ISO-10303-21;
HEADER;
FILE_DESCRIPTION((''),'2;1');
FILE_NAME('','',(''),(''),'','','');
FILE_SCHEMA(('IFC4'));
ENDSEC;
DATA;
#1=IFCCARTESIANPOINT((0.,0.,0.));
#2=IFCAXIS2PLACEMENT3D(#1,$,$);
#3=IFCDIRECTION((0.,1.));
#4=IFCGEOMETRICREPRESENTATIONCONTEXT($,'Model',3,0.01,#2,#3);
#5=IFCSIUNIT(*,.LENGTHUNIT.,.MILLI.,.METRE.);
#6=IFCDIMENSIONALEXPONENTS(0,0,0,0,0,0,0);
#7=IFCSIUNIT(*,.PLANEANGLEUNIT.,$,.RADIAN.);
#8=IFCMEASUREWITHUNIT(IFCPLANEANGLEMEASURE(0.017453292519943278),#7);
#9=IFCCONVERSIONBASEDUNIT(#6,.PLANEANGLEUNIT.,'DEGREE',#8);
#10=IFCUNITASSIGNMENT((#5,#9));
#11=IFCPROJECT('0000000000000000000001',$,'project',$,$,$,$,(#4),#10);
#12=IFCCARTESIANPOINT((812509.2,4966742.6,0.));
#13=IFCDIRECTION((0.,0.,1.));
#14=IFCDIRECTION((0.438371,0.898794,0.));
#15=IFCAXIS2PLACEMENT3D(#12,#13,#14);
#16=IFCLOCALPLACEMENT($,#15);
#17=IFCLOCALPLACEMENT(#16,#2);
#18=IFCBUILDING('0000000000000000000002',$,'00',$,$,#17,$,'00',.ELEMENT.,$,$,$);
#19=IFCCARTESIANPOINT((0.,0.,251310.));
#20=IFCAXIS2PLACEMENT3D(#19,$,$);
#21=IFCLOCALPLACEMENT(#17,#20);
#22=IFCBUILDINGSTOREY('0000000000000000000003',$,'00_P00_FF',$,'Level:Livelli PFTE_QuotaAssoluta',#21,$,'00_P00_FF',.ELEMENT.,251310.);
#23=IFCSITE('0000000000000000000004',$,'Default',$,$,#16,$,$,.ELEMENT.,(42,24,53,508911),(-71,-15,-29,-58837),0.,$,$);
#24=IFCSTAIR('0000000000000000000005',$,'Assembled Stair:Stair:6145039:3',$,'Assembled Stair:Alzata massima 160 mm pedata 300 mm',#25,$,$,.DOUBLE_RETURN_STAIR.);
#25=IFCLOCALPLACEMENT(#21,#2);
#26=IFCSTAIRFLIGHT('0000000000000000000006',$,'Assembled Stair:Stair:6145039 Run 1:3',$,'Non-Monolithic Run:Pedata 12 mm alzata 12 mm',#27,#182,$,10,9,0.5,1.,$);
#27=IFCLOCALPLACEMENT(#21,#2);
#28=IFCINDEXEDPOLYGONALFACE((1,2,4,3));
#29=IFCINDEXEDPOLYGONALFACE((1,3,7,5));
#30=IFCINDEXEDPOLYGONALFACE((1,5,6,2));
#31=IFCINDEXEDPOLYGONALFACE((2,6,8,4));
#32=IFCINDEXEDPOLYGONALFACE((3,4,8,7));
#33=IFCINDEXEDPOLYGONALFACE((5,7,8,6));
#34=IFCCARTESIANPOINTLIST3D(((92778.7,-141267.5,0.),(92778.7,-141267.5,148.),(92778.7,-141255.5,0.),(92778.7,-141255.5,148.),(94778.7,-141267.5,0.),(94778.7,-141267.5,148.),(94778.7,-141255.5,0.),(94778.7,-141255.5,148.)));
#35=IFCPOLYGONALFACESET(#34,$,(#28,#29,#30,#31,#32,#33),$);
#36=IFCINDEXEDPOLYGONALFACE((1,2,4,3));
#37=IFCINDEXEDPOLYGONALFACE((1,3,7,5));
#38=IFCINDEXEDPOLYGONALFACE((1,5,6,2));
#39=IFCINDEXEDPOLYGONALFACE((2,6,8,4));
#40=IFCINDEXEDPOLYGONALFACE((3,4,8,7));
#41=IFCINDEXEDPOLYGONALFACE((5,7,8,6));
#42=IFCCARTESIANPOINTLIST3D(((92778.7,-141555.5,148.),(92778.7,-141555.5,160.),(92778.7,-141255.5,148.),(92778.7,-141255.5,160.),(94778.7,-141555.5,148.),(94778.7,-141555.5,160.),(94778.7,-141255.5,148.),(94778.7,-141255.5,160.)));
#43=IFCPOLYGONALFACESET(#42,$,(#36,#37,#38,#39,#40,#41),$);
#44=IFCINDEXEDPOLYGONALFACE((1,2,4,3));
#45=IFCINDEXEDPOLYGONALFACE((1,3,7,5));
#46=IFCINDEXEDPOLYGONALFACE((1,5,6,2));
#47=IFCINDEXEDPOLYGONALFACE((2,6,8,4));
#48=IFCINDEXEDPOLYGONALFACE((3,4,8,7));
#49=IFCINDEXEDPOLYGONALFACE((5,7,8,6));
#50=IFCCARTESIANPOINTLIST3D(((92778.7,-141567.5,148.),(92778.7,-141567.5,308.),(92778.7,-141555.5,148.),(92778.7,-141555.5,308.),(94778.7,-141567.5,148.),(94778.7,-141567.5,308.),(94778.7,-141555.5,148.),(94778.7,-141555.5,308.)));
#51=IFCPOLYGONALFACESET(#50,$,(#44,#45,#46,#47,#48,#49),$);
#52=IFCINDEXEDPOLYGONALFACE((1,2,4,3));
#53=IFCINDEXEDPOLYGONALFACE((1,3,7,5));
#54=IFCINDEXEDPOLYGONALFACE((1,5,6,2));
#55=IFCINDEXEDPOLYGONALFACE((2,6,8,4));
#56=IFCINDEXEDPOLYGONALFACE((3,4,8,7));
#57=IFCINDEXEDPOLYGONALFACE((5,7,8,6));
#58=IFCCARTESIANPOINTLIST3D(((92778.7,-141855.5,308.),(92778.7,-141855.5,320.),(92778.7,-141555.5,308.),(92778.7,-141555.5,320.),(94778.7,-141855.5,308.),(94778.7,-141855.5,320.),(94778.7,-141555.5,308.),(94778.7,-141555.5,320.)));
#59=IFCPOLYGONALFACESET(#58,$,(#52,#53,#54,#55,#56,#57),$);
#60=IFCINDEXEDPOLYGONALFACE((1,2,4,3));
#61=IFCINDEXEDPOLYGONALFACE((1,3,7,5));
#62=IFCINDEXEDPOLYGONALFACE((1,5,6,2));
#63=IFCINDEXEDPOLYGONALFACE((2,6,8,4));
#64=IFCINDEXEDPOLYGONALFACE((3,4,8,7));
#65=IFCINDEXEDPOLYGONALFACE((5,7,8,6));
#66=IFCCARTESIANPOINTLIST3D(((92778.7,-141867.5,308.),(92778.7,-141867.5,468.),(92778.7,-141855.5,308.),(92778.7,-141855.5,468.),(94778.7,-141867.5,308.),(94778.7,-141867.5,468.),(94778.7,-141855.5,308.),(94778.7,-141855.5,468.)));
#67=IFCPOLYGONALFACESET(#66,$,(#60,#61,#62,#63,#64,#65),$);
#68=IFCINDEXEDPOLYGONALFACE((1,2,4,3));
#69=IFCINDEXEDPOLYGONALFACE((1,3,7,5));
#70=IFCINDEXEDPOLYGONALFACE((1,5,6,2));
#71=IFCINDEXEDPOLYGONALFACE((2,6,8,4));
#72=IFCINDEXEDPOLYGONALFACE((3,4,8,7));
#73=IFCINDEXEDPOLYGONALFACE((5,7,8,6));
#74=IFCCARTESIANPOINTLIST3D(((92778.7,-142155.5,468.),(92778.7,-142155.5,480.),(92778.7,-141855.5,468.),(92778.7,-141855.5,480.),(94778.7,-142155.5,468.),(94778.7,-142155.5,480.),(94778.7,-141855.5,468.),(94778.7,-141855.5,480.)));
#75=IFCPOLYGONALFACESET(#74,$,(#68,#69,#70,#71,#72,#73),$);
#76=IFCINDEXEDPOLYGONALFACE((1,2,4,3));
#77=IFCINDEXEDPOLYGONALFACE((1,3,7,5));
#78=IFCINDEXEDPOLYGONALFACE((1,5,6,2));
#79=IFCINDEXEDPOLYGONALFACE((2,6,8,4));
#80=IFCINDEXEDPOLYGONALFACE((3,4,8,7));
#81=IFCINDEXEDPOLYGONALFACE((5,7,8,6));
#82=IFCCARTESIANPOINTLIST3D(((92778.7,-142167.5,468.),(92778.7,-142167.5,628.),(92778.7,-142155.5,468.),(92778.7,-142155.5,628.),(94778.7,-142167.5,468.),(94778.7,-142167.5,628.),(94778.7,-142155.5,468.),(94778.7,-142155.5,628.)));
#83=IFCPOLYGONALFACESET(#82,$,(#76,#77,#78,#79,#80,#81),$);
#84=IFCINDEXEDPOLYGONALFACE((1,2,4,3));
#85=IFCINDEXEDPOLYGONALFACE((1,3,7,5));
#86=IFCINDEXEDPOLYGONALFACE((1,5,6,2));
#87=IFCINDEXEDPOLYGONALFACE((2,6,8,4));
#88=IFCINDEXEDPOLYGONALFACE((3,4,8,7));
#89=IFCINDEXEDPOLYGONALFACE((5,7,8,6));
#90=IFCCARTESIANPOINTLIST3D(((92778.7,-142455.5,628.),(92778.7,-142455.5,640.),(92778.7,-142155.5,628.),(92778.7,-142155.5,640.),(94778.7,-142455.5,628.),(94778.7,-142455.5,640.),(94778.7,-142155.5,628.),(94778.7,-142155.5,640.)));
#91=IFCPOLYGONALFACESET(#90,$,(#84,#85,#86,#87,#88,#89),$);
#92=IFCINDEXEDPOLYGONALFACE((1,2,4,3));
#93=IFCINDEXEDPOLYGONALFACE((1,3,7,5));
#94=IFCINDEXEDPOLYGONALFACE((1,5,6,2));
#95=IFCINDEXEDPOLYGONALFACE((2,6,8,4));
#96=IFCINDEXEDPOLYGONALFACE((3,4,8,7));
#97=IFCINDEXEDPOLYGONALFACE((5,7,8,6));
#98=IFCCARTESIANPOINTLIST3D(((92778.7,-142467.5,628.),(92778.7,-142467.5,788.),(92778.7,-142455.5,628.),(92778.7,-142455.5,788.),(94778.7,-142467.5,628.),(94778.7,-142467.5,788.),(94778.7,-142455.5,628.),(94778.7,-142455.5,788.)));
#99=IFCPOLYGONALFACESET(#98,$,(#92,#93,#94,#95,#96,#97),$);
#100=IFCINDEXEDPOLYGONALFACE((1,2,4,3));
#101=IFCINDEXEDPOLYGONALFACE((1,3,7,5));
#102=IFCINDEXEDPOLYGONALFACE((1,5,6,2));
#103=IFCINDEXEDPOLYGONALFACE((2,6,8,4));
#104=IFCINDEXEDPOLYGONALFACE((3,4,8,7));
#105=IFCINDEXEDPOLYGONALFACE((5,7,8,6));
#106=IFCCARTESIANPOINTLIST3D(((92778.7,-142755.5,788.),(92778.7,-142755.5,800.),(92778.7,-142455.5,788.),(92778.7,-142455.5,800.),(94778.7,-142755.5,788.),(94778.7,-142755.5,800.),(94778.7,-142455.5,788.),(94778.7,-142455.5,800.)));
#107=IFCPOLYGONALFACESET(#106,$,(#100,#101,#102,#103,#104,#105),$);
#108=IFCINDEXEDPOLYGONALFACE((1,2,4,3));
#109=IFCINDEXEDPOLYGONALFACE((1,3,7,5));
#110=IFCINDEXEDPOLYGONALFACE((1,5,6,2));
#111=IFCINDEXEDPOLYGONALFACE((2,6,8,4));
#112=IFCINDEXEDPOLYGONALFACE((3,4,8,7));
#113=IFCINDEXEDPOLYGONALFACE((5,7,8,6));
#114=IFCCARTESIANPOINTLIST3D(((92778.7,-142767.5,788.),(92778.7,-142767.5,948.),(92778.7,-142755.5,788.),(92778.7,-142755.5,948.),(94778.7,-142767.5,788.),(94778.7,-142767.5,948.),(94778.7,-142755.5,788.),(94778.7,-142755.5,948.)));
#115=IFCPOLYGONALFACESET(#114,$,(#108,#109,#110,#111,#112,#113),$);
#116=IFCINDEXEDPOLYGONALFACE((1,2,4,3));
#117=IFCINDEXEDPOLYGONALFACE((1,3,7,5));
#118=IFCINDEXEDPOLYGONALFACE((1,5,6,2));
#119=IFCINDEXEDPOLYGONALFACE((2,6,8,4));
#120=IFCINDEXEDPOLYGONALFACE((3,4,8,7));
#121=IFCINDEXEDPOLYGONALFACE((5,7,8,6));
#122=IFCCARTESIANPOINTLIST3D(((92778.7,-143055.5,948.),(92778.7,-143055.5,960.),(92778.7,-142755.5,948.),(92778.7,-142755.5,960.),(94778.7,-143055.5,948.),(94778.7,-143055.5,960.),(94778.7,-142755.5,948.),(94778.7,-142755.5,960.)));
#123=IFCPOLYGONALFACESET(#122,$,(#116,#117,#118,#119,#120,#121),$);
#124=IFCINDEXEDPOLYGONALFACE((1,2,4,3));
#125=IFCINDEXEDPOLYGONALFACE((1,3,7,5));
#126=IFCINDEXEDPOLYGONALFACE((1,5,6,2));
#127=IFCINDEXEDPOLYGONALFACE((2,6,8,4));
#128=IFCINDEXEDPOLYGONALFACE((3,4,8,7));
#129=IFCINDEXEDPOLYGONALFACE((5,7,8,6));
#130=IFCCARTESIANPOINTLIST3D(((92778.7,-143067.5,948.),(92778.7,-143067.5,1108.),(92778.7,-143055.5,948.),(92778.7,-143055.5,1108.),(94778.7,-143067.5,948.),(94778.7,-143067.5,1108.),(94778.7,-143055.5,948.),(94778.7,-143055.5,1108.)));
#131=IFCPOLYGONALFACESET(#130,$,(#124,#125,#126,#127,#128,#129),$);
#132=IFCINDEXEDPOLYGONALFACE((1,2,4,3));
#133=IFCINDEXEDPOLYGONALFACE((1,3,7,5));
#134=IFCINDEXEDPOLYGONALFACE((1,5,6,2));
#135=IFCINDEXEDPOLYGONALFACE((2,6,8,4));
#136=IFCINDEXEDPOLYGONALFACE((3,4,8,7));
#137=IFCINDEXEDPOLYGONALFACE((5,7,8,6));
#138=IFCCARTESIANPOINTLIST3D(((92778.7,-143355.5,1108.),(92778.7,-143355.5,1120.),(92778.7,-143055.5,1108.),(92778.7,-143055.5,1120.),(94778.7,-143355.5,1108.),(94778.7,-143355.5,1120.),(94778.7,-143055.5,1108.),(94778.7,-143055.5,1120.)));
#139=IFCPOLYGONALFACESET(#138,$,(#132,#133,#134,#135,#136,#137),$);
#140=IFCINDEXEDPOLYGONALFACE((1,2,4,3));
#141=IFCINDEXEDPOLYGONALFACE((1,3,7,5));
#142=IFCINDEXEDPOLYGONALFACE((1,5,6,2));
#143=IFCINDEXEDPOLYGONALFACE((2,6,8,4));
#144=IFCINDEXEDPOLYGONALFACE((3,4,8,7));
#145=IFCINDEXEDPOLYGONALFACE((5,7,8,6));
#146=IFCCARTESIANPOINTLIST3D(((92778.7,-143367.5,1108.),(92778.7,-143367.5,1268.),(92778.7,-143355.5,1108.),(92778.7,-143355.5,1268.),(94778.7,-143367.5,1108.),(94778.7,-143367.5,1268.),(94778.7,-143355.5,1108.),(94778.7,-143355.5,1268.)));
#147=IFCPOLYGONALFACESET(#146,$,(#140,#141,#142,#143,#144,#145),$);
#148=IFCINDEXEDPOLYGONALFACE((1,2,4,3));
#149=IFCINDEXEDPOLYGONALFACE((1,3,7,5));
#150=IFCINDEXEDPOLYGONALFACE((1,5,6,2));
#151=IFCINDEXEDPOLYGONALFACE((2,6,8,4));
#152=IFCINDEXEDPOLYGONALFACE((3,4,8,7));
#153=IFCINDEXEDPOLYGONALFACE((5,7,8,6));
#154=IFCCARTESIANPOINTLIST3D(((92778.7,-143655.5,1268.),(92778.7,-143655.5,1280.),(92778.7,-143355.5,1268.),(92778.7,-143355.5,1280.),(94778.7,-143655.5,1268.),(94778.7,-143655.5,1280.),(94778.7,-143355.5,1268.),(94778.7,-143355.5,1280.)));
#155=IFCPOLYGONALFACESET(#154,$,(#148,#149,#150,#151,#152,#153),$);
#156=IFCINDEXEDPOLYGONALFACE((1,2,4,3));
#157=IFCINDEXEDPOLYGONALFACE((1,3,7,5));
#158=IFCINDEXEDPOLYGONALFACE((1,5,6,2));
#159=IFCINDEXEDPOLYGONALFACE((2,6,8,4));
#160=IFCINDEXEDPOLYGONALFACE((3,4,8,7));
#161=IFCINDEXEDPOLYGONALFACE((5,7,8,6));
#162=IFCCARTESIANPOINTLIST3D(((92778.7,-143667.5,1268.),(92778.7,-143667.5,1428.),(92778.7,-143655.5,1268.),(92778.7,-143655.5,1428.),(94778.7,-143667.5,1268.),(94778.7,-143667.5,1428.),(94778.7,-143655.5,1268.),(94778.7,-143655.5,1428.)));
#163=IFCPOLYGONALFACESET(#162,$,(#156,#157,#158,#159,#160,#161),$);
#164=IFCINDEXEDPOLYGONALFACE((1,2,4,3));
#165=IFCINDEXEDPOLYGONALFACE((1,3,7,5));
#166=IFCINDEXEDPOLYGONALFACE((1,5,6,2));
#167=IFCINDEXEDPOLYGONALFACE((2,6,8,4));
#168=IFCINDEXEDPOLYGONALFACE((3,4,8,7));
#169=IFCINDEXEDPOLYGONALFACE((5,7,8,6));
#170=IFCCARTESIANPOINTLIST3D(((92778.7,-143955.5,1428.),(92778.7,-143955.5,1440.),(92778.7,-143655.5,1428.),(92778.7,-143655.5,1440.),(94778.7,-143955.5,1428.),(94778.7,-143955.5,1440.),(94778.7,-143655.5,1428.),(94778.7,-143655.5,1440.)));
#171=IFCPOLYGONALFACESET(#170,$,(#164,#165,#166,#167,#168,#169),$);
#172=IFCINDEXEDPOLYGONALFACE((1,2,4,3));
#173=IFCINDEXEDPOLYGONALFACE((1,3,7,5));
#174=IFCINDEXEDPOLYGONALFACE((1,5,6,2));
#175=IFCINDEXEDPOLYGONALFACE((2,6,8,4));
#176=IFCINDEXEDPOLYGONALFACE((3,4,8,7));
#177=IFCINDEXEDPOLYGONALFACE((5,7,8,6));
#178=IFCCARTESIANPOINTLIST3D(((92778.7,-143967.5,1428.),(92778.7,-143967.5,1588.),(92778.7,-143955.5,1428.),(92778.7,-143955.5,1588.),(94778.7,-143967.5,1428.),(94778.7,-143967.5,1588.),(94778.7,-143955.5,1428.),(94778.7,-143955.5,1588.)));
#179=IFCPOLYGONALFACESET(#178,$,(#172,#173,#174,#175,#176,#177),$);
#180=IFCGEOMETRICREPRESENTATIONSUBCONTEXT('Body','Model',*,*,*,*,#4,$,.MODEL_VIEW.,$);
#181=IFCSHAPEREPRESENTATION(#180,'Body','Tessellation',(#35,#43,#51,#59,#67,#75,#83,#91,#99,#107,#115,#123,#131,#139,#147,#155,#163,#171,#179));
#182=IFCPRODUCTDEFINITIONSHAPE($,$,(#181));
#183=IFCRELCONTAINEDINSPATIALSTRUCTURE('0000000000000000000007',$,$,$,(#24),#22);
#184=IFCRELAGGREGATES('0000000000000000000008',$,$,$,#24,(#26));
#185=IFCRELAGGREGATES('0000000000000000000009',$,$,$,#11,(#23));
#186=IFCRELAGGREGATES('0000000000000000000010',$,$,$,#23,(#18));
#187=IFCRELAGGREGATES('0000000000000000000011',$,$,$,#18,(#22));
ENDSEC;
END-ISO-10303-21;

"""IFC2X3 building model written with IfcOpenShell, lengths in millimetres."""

from ifc_helpers import new_model, entity, si_unit, converted_unit, direction, frame, frame_2d, origin, origin_2d_with_axis, place, context, subcontext, project, spatial, rectangle, extrude, element, aggregate, save


model = new_model("IFC2X3")

# Units and contexts
model_context = context("Model", 3, precision=0.01, world=origin(), true_north=direction((0.0, 1.0)))
body_context = subcontext(model_context, "Body", "Model", "MODEL_VIEW")
ifc_project = project(units=[si_unit("LENGTHUNIT", "METRE", prefix="MILLI"), converted_unit("PLANEANGLEUNIT", "DEGREE", entity("IfcPlaneAngleMeasure", 0.017453292519943278), si_unit("PLANEANGLEUNIT", "RADIAN"), dimensions=[0, 0, 0, 0, 0, 0, 0])], contexts=[model_context])

# Site, building, storey
site_placement = place(None, frame((812509.2, 4966742.6, 0.0), z_axis=(0.0, 0.0, 1.0), x_axis=(0.438371, 0.898794, 0.0)))
site = spatial("IfcSite", under=ifc_project, at=site_placement, Name="Default", CompositionType="ELEMENT", RefLatitude=(42, 24, 53, 508911), RefLongitude=(-71, -15, -29, -58837), RefElevation=0.0)
building_placement = place(site_placement, origin())
building = spatial("IfcBuilding", under=site, at=building_placement, Name="00", LongName="00", CompositionType="ELEMENT")
storey_placement = place(building_placement, frame((0.0, 0.0, 251310.0)))
storey = spatial("IfcBuildingStorey", under=building, at=storey_placement, Name="00_P00_FF", ObjectType="Level:Livelli PFTE_QuotaAssoluta", LongName="00_P00_FF", CompositionType="ELEMENT", Elevation=251310.0)

# Stair
stair_1_placement = place(storey_placement, origin())
stair_1 = element("IfcStair", 1, at=stair_1_placement, inside=storey, Name="Assembled Stair:Stair:6145039:3", ObjectType="Assembled Stair:Alzata massima 160 mm pedata 300 mm", ShapeType="DOUBLE_RETURN_STAIR")

# Stair flight
stair_flight_1_placement = place(stair_1_placement, origin())
stair_flight_1 = element("IfcStairFlight", 2, at=stair_flight_1_placement, Name="Assembled Stair:Stair:6145039 Run 1:3", ObjectType="Non-Monolithic Run:Pedata 12 mm alzata 12 mm", NumberOfRiser=10, NumberOfTreads=9, RiserHeight=0.5, TreadLength=1.0, context=body_context, shape_type="SweptSolid", body=[
    extrude(rectangle(XDim=2000.0, YDim=12.0, at=origin_2d_with_axis()), frame((93778.7, -141261.5, 0.0)), (0.0, 0.0, 1.0), 148.0),
    extrude(rectangle(XDim=300.0, YDim=2000.0, at=frame_2d((0.0, 0.0), x_axis=(1.0, 0.0))), frame((93778.7, -141405.5, 148.0), z_axis=(0.0, 0.0, 1.0), x_axis=(0.0, 1.0, 0.0)), (0.0, 0.0, 1.0), 12.0),
    extrude(rectangle(XDim=2000.0, YDim=12.0, at=origin_2d_with_axis()), frame((93778.7, -141561.5, 148.0)), (0.0, 0.0, 1.0), 160.0),
    extrude(rectangle(XDim=300.0, YDim=2000.0, at=origin_2d_with_axis()), frame((93778.7, -141705.5, 308.0), z_axis=(0.0, 0.0, 1.0), x_axis=(0.0, 1.0, 0.0)), (0.0, 0.0, 1.0), 12.0),
    extrude(rectangle(XDim=2000.0, YDim=12.0, at=origin_2d_with_axis()), frame((93778.7, -141861.5, 308.0)), (0.0, 0.0, 1.0), 160.0),
    extrude(rectangle(XDim=300.0, YDim=2000.0, at=origin_2d_with_axis()), frame((93778.7, -142005.5, 468.0), z_axis=(0.0, 0.0, 1.0), x_axis=(0.0, 1.0, 0.0)), (0.0, 0.0, 1.0), 12.0),
    extrude(rectangle(XDim=2000.0, YDim=12.0, at=origin_2d_with_axis()), frame((93778.7, -142161.5, 468.0)), (0.0, 0.0, 1.0), 160.0),
    extrude(rectangle(XDim=300.0, YDim=2000.0, at=origin_2d_with_axis()), frame((93778.7, -142305.5, 628.0), z_axis=(0.0, 0.0, 1.0), x_axis=(0.0, 1.0, 0.0)), (0.0, 0.0, 1.0), 12.0),
    extrude(rectangle(XDim=2000.0, YDim=12.0, at=origin_2d_with_axis()), frame((93778.7, -142461.5, 628.0)), (0.0, 0.0, 1.0), 160.0),
    extrude(rectangle(XDim=300.0, YDim=2000.0, at=origin_2d_with_axis()), frame((93778.7, -142605.5, 788.0), z_axis=(0.0, 0.0, 1.0), x_axis=(0.0, 1.0, 0.0)), (0.0, 0.0, 1.0), 12.0),
    extrude(rectangle(XDim=2000.0, YDim=12.0, at=origin_2d_with_axis()), frame((93778.7, -142761.5, 788.0)), (0.0, 0.0, 1.0), 160.0),
    extrude(rectangle(XDim=300.0, YDim=2000.0, at=origin_2d_with_axis()), frame((93778.7, -142905.5, 948.0), z_axis=(0.0, 0.0, 1.0), x_axis=(0.0, 1.0, 0.0)), (0.0, 0.0, 1.0), 12.0),
    extrude(rectangle(XDim=2000.0, YDim=12.0, at=origin_2d_with_axis()), frame((93778.7, -143061.5, 948.0)), (0.0, 0.0, 1.0), 160.0),
    extrude(rectangle(XDim=300.0, YDim=2000.0, at=origin_2d_with_axis()), frame((93778.7, -143205.5, 1108.0), z_axis=(0.0, 0.0, 1.0), x_axis=(0.0, 1.0, 0.0)), (0.0, 0.0, 1.0), 12.0),
    extrude(rectangle(XDim=2000.0, YDim=12.0, at=origin_2d_with_axis()), frame((93778.7, -143361.5, 1108.0)), (0.0, 0.0, 1.0), 160.0),
    extrude(rectangle(XDim=300.0, YDim=2000.0, at=origin_2d_with_axis()), frame((93778.7, -143505.5, 1268.0), z_axis=(0.0, 0.0, 1.0), x_axis=(0.0, 1.0, 0.0)), (0.0, 0.0, 1.0), 12.0),
    extrude(rectangle(XDim=2000.0, YDim=12.0, at=origin_2d_with_axis()), frame((93778.7, -143661.5, 1268.0)), (0.0, 0.0, 1.0), 160.0),
    extrude(rectangle(XDim=300.0, YDim=2000.0, at=origin_2d_with_axis()), frame((93778.7, -143805.5, 1428.0), z_axis=(0.0, 0.0, 1.0), x_axis=(0.0, 1.0, 0.0)), (0.0, 0.0, 1.0), 12.0),
    extrude(rectangle(XDim=2000.0, YDim=12.0, at=origin_2d_with_axis()), frame((93778.7, -143961.5, 1428.0)), (0.0, 0.0, 1.0), 160.0),
])
aggregate(stair_1, [stair_flight_1])

save(model, "model.ifc")
